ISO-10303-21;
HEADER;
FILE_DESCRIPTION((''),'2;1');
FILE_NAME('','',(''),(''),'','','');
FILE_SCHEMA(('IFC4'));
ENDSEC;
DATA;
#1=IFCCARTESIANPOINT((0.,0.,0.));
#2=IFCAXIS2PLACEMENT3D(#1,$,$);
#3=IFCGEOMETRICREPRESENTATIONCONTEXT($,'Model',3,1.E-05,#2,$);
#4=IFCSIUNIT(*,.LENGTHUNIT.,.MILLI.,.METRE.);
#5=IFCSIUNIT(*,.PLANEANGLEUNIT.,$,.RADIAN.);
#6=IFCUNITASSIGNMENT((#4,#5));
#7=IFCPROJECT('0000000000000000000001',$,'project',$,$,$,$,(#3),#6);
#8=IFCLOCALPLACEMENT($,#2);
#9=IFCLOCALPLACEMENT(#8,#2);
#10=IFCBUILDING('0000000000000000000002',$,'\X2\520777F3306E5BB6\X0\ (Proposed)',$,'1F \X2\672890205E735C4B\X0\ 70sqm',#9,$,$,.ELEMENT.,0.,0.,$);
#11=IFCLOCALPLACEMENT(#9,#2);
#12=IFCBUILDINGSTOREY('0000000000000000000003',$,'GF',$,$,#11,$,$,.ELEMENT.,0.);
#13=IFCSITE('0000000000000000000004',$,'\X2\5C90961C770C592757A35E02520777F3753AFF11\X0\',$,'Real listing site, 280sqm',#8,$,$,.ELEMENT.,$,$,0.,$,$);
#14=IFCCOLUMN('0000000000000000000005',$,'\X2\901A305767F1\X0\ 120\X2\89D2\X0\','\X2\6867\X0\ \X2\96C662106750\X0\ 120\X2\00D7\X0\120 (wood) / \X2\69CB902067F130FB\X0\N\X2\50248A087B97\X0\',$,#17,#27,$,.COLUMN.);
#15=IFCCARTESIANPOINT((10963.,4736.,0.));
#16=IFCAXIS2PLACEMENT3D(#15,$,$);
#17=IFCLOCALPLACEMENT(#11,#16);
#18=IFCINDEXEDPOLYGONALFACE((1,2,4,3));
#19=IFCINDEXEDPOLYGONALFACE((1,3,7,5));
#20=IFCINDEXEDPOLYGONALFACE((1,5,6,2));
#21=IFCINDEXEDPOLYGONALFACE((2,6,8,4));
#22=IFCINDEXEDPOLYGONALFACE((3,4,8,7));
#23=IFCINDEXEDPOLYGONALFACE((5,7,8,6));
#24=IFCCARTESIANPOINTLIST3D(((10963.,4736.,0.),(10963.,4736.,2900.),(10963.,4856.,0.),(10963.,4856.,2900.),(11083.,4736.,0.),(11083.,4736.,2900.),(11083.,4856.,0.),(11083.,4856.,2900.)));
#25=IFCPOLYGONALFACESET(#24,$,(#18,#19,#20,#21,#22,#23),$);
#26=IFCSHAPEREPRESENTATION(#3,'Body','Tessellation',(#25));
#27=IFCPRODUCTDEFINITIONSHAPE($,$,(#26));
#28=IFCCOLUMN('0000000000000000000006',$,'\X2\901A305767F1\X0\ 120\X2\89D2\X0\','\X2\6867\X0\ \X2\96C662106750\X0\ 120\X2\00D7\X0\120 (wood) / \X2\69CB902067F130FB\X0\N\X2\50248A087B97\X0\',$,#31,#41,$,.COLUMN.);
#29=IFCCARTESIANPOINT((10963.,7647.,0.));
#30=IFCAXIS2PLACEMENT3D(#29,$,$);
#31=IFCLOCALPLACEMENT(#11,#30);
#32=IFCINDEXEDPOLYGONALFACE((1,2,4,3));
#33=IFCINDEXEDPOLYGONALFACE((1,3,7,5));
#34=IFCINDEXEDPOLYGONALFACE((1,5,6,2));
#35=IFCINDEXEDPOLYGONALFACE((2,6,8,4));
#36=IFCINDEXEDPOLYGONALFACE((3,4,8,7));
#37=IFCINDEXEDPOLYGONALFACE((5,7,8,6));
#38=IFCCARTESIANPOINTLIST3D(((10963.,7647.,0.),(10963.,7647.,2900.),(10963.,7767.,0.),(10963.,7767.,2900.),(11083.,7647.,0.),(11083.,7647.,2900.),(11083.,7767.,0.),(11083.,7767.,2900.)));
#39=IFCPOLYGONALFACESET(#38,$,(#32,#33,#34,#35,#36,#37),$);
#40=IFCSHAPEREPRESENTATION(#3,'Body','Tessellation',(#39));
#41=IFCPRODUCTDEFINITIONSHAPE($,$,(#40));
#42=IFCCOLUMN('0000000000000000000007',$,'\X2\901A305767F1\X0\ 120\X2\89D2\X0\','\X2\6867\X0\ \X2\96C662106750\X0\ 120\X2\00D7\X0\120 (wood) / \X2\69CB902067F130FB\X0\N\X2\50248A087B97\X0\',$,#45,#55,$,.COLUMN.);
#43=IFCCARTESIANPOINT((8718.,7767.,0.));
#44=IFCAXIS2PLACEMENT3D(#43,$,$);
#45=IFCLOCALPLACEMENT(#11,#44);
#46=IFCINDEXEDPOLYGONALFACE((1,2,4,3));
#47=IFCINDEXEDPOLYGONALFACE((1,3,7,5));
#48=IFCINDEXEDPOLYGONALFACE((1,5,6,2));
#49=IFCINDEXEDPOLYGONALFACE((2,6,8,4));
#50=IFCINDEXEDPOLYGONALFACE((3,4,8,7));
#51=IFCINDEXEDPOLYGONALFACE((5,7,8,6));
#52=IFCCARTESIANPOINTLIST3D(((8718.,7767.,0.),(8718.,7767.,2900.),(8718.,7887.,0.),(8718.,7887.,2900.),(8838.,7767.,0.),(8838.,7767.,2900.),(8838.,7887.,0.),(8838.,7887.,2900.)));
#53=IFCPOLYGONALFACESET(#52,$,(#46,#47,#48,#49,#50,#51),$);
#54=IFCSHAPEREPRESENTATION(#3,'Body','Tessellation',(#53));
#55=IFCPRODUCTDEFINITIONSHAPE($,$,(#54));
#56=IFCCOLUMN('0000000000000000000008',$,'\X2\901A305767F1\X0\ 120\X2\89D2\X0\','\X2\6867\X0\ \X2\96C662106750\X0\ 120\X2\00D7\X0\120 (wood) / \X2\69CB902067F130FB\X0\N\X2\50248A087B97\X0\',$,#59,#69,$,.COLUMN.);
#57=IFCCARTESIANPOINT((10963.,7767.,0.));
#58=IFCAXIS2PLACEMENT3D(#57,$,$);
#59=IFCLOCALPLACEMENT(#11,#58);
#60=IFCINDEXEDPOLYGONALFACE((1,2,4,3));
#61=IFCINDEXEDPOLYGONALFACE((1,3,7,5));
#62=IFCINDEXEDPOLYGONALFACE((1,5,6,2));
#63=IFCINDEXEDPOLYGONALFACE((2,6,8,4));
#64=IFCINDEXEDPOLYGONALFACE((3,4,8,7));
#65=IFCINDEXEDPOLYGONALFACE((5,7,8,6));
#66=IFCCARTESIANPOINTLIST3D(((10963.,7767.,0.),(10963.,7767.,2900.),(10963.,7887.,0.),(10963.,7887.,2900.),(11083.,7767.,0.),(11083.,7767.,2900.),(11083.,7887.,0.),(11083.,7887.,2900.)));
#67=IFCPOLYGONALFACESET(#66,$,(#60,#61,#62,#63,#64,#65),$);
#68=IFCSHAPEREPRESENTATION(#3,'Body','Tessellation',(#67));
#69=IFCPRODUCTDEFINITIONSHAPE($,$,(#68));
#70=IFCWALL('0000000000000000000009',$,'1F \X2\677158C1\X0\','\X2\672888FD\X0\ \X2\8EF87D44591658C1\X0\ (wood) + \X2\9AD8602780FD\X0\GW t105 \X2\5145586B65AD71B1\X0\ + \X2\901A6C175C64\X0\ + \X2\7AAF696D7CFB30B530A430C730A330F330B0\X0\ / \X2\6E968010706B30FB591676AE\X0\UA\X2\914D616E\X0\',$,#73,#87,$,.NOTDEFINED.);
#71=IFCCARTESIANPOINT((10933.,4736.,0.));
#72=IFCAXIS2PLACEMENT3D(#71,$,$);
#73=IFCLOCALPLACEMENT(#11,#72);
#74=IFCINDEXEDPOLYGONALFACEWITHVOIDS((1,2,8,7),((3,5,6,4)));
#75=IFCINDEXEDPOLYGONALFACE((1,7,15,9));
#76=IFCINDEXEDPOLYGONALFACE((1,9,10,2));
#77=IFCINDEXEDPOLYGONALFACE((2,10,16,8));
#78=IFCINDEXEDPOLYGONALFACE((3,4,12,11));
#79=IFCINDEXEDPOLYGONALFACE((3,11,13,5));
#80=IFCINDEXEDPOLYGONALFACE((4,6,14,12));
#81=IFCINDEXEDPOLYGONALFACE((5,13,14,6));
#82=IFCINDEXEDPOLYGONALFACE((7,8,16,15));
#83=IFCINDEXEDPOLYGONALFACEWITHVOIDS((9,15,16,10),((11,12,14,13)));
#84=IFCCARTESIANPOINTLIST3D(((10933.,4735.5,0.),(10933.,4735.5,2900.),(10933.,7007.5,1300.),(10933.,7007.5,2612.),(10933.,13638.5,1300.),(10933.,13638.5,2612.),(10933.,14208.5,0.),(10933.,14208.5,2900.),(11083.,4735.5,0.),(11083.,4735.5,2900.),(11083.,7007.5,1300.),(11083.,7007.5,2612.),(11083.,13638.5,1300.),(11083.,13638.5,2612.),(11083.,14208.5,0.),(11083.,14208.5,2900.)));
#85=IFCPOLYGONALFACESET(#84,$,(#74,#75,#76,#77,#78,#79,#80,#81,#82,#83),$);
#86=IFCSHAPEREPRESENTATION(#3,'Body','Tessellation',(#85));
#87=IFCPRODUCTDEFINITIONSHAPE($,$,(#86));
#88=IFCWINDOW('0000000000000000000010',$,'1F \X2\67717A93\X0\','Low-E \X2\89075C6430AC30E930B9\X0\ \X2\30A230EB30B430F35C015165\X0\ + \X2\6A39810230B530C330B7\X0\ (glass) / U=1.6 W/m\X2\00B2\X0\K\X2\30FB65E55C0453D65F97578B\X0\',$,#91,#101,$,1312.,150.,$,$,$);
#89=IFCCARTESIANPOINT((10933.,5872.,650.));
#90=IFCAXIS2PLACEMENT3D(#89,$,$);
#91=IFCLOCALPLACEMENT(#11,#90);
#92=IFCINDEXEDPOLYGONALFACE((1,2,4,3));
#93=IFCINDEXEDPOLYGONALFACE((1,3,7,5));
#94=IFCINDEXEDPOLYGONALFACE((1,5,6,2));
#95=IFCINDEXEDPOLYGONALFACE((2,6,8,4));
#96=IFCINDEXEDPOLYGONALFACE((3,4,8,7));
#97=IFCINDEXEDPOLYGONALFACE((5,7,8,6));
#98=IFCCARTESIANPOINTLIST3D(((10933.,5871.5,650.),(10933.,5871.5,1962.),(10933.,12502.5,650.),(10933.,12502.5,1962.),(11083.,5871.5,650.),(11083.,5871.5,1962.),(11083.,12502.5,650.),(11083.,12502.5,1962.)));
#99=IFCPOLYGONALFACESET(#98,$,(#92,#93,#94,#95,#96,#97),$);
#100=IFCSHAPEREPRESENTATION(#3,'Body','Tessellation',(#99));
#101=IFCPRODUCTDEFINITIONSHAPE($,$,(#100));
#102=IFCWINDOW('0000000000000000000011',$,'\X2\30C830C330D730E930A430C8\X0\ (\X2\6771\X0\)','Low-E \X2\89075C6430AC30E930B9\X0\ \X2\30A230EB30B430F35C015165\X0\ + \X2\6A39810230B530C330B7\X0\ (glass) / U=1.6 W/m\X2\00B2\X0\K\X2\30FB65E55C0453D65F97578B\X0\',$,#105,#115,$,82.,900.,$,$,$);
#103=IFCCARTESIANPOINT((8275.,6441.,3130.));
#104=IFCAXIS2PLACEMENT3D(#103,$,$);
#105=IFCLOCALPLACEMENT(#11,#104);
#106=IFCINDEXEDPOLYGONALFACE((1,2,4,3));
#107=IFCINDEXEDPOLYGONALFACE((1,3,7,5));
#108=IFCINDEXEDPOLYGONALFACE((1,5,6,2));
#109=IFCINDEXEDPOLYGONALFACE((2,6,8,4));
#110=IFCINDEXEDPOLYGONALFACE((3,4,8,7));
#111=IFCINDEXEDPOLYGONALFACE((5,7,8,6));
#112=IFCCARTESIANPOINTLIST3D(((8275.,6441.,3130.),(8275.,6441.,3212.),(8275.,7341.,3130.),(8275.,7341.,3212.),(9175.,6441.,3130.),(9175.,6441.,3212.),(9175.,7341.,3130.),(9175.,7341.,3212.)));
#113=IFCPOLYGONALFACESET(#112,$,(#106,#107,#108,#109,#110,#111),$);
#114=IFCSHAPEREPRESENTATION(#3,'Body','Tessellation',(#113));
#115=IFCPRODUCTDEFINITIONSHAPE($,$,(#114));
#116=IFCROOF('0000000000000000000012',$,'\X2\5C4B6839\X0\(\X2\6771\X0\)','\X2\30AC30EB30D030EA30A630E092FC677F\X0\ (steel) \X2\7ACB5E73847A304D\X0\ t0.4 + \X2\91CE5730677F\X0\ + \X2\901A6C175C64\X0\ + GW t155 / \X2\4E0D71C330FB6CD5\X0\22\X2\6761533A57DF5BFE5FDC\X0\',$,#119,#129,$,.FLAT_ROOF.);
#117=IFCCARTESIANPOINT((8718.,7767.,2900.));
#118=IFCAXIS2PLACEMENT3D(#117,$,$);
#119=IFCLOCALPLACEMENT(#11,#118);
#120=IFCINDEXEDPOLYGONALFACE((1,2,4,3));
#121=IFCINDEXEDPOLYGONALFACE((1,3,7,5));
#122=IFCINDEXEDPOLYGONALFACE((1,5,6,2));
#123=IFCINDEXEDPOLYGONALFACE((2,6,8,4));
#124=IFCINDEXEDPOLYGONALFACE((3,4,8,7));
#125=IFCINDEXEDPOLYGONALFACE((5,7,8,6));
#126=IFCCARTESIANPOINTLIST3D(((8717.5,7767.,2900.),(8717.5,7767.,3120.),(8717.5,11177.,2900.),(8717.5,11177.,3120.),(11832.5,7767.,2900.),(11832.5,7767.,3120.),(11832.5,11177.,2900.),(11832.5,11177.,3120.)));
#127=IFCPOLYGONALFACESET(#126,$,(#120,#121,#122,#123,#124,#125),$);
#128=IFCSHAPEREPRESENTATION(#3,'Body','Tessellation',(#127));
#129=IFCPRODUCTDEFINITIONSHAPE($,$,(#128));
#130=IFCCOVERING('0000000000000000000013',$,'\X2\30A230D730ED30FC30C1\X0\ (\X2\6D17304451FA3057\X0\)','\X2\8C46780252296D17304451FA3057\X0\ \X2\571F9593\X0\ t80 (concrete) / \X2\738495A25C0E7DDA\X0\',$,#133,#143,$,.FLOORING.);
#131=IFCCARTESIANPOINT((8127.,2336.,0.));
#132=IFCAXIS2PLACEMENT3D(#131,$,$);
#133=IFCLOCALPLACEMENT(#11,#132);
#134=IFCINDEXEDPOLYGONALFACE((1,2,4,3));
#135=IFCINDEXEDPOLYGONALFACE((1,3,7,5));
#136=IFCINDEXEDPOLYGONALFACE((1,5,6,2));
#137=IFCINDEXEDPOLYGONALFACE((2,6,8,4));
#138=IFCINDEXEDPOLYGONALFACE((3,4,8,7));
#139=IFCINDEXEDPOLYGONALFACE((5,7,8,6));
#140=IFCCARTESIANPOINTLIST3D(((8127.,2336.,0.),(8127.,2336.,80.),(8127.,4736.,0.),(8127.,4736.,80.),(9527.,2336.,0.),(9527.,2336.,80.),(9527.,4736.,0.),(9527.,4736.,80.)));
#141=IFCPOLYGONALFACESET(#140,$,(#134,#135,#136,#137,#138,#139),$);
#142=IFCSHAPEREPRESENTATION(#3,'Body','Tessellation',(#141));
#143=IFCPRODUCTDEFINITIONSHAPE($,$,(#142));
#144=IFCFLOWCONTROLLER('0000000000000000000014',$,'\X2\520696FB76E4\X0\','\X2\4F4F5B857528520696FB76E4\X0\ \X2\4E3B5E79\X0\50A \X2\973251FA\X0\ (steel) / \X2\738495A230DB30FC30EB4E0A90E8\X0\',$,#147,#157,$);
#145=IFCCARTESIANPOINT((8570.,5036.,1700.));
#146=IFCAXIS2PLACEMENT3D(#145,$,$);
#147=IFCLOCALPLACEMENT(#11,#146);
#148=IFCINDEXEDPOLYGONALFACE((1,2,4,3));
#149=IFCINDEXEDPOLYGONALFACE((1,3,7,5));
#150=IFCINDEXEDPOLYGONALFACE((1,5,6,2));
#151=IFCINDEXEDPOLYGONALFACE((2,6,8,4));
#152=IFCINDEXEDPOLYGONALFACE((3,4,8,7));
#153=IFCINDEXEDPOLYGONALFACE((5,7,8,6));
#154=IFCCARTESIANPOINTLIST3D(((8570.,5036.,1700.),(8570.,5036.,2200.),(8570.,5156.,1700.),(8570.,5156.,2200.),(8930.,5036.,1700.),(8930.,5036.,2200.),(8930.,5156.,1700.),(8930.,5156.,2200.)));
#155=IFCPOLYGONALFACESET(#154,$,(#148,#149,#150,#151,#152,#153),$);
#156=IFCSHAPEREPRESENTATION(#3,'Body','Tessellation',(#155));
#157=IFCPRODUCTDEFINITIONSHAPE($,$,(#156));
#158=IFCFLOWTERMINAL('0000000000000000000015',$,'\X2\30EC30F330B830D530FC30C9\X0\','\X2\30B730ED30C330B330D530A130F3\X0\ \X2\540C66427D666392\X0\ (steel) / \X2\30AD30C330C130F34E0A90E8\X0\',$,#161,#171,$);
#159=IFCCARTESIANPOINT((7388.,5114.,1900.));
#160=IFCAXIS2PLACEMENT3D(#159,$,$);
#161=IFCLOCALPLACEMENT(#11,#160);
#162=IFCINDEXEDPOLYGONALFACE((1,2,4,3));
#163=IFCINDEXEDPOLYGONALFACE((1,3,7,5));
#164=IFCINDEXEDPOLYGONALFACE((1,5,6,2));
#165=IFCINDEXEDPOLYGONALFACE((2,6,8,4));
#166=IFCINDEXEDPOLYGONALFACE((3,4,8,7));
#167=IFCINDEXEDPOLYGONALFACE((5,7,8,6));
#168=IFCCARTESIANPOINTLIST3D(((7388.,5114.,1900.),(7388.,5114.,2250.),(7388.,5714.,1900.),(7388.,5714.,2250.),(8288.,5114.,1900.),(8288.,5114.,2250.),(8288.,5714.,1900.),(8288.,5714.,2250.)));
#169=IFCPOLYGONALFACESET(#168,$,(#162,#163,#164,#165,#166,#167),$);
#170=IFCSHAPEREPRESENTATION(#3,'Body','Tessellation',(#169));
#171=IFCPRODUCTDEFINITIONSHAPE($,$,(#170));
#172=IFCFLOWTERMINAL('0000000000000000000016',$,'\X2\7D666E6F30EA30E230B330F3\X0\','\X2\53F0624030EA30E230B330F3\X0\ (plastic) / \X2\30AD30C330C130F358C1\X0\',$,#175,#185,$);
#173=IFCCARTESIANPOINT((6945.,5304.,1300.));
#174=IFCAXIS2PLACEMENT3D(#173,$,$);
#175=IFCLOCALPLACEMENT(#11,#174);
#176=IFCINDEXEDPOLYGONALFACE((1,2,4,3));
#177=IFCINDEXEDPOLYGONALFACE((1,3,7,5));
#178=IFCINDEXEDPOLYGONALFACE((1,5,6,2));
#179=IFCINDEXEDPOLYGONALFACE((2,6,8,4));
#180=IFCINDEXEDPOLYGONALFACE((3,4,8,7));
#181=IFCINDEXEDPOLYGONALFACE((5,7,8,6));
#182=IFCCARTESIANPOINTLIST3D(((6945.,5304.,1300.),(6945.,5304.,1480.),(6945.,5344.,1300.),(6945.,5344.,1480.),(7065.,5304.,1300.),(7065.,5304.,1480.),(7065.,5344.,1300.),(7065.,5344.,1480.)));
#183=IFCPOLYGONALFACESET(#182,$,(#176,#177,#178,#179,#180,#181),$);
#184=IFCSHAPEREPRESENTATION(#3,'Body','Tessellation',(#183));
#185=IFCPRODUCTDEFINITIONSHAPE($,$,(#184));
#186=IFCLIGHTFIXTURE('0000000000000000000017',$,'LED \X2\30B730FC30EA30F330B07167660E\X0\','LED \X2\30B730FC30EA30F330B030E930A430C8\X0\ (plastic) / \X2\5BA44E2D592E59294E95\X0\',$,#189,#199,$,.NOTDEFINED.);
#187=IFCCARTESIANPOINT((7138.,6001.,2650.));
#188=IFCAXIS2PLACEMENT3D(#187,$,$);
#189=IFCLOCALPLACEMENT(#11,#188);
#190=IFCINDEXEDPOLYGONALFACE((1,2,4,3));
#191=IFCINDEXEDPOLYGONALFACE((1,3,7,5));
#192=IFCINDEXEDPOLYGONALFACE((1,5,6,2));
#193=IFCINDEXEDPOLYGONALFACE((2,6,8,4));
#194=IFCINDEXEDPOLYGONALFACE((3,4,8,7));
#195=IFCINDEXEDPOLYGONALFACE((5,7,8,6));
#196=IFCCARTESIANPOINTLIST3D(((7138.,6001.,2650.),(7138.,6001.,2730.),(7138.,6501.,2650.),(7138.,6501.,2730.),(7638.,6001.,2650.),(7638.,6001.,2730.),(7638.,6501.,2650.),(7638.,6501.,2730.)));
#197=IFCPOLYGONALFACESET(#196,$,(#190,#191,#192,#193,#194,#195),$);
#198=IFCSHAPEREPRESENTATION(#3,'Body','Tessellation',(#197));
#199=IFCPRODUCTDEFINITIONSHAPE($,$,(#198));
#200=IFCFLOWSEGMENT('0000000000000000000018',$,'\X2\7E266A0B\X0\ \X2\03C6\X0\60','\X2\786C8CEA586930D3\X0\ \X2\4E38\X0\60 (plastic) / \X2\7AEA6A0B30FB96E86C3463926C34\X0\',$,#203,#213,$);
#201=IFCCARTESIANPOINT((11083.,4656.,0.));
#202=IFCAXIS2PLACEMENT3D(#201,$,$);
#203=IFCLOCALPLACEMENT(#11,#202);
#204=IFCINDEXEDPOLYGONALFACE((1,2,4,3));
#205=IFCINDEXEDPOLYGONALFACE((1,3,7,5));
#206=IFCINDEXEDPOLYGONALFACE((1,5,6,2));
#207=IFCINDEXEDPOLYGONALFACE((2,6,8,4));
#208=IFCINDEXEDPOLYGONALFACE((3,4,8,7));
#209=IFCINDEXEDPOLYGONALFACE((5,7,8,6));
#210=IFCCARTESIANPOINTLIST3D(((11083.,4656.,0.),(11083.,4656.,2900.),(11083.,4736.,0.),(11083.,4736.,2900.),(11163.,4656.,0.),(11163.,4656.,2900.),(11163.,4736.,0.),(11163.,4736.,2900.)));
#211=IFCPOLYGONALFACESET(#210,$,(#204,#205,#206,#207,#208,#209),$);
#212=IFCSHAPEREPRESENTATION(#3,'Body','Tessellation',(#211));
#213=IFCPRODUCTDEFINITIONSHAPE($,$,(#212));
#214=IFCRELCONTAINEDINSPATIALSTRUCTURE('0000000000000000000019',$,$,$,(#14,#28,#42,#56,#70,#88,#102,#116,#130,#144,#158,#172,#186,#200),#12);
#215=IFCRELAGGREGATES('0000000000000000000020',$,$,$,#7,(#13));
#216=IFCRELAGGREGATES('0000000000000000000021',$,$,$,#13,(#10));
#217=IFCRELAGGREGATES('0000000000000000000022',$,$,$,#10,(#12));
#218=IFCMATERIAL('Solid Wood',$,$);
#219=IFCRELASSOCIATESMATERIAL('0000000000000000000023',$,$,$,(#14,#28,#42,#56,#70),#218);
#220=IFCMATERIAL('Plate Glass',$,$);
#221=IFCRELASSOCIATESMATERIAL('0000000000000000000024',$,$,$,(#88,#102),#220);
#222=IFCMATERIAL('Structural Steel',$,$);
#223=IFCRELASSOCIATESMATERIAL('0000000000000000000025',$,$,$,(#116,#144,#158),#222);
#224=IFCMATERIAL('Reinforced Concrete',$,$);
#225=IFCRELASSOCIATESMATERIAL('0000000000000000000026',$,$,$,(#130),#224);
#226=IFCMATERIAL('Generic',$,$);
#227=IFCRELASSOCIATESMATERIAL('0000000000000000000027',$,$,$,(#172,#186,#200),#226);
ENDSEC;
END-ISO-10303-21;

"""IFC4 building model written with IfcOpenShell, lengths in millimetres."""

from ifc_helpers import new_model, si_unit, frame, frame_2d, origin, place, context, project, spatial, rectangle, extrude, material, element, fill, save


model = new_model("IFC4")

# Units and contexts
model_context = context("Model", 3, precision=1e-05, world=origin())
ifc_project = project(units=[si_unit("LENGTHUNIT", "METRE", prefix="MILLI"), si_unit("PLANEANGLEUNIT", "RADIAN")], contexts=[model_context])

# Site, building, storey
site_placement = place(None, origin())
site = spatial("IfcSite", under=ifc_project, at=site_placement, Name="岐阜県大垣市切石町１", ObjectType="Real listing site, 280sqm", CompositionType="ELEMENT", RefElevation=0.0)
building_placement = place(site_placement, origin())
building = spatial("IfcBuilding", under=site, at=building_placement, Name="切石の家 (Proposed)", ObjectType="1F 木造平屋 70sqm", CompositionType="ELEMENT", ElevationOfRefHeight=0.0, ElevationOfTerrain=0.0)
storey_placement = place(building_placement, origin())
storey = spatial("IfcBuildingStorey", under=building, at=storey_placement, Name="GF", CompositionType="ELEMENT", Elevation=0.0)

# Columns
ifc_material_1 = material(Name="Solid Wood")
column_1_placement = place(storey_placement, frame((10963.0, 4736.0, 0.0)))
element("IfcColumn", 1, at=column_1_placement, inside=storey, material=ifc_material_1, Name="通し柱 120角", Description="桧 集成材 120×120 (wood) / 構造柱・N値計算", PredefinedType="COLUMN", context=model_context, shape_type="SweptSolid", body=[
    extrude(rectangle(XDim=120.0, YDim=120.0, at=frame_2d((60.0, 60.0))), frame((10963.0, 4736.0, 0.0)), (0.0, 0.0, 1.0), 2900.0),
])
column_2_placement = place(storey_placement, frame((10963.0, 7647.0, 0.0)))
element("IfcColumn", 2, at=column_2_placement, inside=storey, material=ifc_material_1, Name="通し柱 120角", Description="桧 集成材 120×120 (wood) / 構造柱・N値計算", PredefinedType="COLUMN", context=model_context, shape_type="SweptSolid", body=[
    extrude(rectangle(XDim=120.0, YDim=120.0, at=frame_2d((60.0, 60.0))), frame((10963.0, 7647.0, 0.0)), (0.0, 0.0, 1.0), 2900.0),
])
column_3_placement = place(storey_placement, frame((8718.0, 7767.0, 0.0)))
element("IfcColumn", 3, at=column_3_placement, inside=storey, material=ifc_material_1, Name="通し柱 120角", Description="桧 集成材 120×120 (wood) / 構造柱・N値計算", PredefinedType="COLUMN", context=model_context, shape_type="SweptSolid", body=[
    extrude(rectangle(XDim=120.0, YDim=120.0, at=frame_2d((60.0, 60.0))), frame((8718.0, 7767.0, 0.0)), (0.0, 0.0, 1.0), 2900.0),
])
column_4_placement = place(storey_placement, frame((10963.0, 7767.0, 0.0)))
element("IfcColumn", 4, at=column_4_placement, inside=storey, material=ifc_material_1, Name="通し柱 120角", Description="桧 集成材 120×120 (wood) / 構造柱・N値計算", PredefinedType="COLUMN", context=model_context, shape_type="SweptSolid", body=[
    extrude(rectangle(XDim=120.0, YDim=120.0, at=frame_2d((60.0, 60.0))), frame((10963.0, 7767.0, 0.0)), (0.0, 0.0, 1.0), 2900.0),
])

# Wall, opening, window
wall_1_placement = place(storey_placement, frame((10933.0, 4736.0, 0.0)))
wall_1 = element("IfcWall", 5, at=wall_1_placement, inside=storey, material=ifc_material_1, Name="1F 東壁", Description="木製 軸組外壁 (wood) + 高性能GW t105 充填断熱 + 通気層 + 窯業系サイディング / 準耐火・外皮UA配慮", PredefinedType="NOTDEFINED", context=model_context, shape_type="SweptSolid", body=[
    extrude(rectangle(XDim=150.0, YDim=9473.0, at=frame_2d((75.0, 4736.0))), frame((10933.0, 4736.0, 0.0)), (0.0, 0.0, 1.0), 2900.0),
])
opening_placement = place(storey_placement, frame((10933.0, 5872.0, 650.0)))
opening = element("IfcOpeningElement", 6, at=opening_placement, cuts=wall_1, PredefinedType="NOTDEFINED", context=model_context, shape_type="SweptSolid", body=[
    extrude(rectangle(XDim=150.0, YDim=6631.0, at=frame_2d((75.0, 3315.0))), frame((10933.0, 5872.0, 650.0)), (0.0, 0.0, 1.0), 1312.0),
])
ifc_material_2 = material(Name="Plate Glass")
window_1_placement = place(storey_placement, frame((10933.0, 5872.0, 650.0)))
window_1 = element("IfcWindow", 7, at=window_1_placement, inside=storey, material=ifc_material_2, Name="1F 東窓", Description="Low-E 複層ガラス アルゴン封入 + 樹脂サッシ (glass) / U=1.6 W/m²K・日射取得型", OverallHeight=1312.0, OverallWidth=150.0, context=model_context, shape_type="SweptSolid", body=[
    extrude(rectangle(XDim=150.0, YDim=6631.0, at=frame_2d((75.0, 3315.0))), frame((10933.0, 5872.0, 650.0)), (0.0, 0.0, 1.0), 1312.0),
])
fill(opening, window_1)

# Window
window_2_placement = place(storey_placement, frame((8275.0, 6441.0, 3130.0)))
element("IfcWindow", 8, at=window_2_placement, inside=storey, material=ifc_material_2, Name="トップライト (東)", Description="Low-E 複層ガラス アルゴン封入 + 樹脂サッシ (glass) / U=1.6 W/m²K・日射取得型", OverallHeight=82.0, OverallWidth=900.0, context=model_context, shape_type="SweptSolid", body=[
    extrude(rectangle(XDim=900.0, YDim=900.0, at=frame_2d((450.0, 450.0))), frame((8275.0, 6441.0, 3130.0)), (0.0, 0.0, 1.0), 82.0),
])

# Roof
ifc_material_3 = material(Name="Structural Steel")
roof_placement = place(storey_placement, frame((8718.0, 7767.0, 2900.0)))
element("IfcRoof", 9, at=roof_placement, inside=storey, material=ifc_material_3, Name="屋根(東)", Description="ガルバリウム鋼板 (steel) 立平葺き t0.4 + 野地板 + 通気層 + GW t155 / 不燃・法22条区域対応", PredefinedType="FLAT_ROOF", context=model_context, shape_type="SweptSolid", body=[
    extrude(rectangle(XDim=3115.0, YDim=3410.0, at=frame_2d((1557.0, 1705.0))), frame((8718.0, 7767.0, 2900.0)), (0.0, 0.0, 1.0), 220.0),
])

# Covering
ifc_material_4 = material(Name="Reinforced Concrete")
covering_placement = place(storey_placement, frame((8127.0, 2336.0, 0.0)))
element("IfcCovering", 10, at=covering_placement, inside=storey, material=ifc_material_4, Name="アプローチ (洗い出し)", Description="豆砂利洗い出し 土間 t80 (concrete) / 玄関導線", PredefinedType="FLOORING", context=model_context, shape_type="SweptSolid", body=[
    extrude(rectangle(XDim=1400.0, YDim=2400.0, at=frame_2d((700.0, 1200.0))), frame((8127.0, 2336.0, 0.0)), (0.0, 0.0, 1.0), 80.0),
])

# Flow controller
flow_controller_placement = place(storey_placement, frame((8570.0, 5036.0, 1700.0)))
element("IfcFlowController", 11, at=flow_controller_placement, inside=storey, material=ifc_material_3, Name="分電盤", Description="住宅用分電盤 主幹50A 露出 (steel) / 玄関ホール上部", context=model_context, shape_type="SweptSolid", body=[
    extrude(rectangle(XDim=360.0, YDim=120.0, at=frame_2d((180.0, 60.0))), frame((8570.0, 5036.0, 1700.0)), (0.0, 0.0, 1.0), 500.0),
])

# Flow terminals
flow_terminal_1_placement = place(storey_placement, frame((7388.0, 5114.0, 1900.0)))
element("IfcFlowTerminal", 12, at=flow_terminal_1_placement, inside=storey, material=ifc_material_3, Name="レンジフード", Description="シロッコファン 同時給排 (steel) / キッチン上部", context=model_context, shape_type="SweptSolid", body=[
    extrude(rectangle(XDim=900.0, YDim=600.0, at=frame_2d((450.0, 300.0))), frame((7388.0, 5114.0, 1900.0)), (0.0, 0.0, 1.0), 350.0),
])
ifc_material_5 = material(Name="Generic")
flow_terminal_2_placement = place(storey_placement, frame((6945.0, 5304.0, 1300.0)))
element("IfcFlowTerminal", 13, at=flow_terminal_2_placement, inside=storey, material=ifc_material_5, Name="給湯リモコン", Description="台所リモコン (plastic) / キッチン壁", context=model_context, shape_type="SweptSolid", body=[
    extrude(rectangle(XDim=120.0, YDim=40.0, at=frame_2d((60.0, 20.0))), frame((6945.0, 5304.0, 1300.0)), (0.0, 0.0, 1.0), 180.0),
])

# Light fixture
light_fixture_placement = place(storey_placement, frame((7138.0, 6001.0, 2650.0)))
element("IfcLightFixture", 14, at=light_fixture_placement, inside=storey, material=ifc_material_5, Name="LED シーリング照明", Description="LED シーリングライト (plastic) / 室中央天井", PredefinedType="NOTDEFINED", context=model_context, shape_type="SweptSolid", body=[
    extrude(rectangle(XDim=500.0, YDim=500.0, at=frame_2d((250.0, 250.0))), frame((7138.0, 6001.0, 2650.0)), (0.0, 0.0, 1.0), 80.0),
])

# Flow segment
flow_segment_placement = place(storey_placement, frame((11083.0, 4656.0, 0.0)))
element("IfcFlowSegment", 15, at=flow_segment_placement, inside=storey, material=ifc_material_5, Name="縦樋 φ60", Description="硬質塩ビ 丸60 (plastic) / 竪樋・雨水排水", context=model_context, shape_type="SweptSolid", body=[
    extrude(rectangle(XDim=80.0, YDim=80.0, at=frame_2d((40.0, 40.0))), frame((11083.0, 4656.0, 0.0)), (0.0, 0.0, 1.0), 2900.0),
])

save(model, "model.ifc")
